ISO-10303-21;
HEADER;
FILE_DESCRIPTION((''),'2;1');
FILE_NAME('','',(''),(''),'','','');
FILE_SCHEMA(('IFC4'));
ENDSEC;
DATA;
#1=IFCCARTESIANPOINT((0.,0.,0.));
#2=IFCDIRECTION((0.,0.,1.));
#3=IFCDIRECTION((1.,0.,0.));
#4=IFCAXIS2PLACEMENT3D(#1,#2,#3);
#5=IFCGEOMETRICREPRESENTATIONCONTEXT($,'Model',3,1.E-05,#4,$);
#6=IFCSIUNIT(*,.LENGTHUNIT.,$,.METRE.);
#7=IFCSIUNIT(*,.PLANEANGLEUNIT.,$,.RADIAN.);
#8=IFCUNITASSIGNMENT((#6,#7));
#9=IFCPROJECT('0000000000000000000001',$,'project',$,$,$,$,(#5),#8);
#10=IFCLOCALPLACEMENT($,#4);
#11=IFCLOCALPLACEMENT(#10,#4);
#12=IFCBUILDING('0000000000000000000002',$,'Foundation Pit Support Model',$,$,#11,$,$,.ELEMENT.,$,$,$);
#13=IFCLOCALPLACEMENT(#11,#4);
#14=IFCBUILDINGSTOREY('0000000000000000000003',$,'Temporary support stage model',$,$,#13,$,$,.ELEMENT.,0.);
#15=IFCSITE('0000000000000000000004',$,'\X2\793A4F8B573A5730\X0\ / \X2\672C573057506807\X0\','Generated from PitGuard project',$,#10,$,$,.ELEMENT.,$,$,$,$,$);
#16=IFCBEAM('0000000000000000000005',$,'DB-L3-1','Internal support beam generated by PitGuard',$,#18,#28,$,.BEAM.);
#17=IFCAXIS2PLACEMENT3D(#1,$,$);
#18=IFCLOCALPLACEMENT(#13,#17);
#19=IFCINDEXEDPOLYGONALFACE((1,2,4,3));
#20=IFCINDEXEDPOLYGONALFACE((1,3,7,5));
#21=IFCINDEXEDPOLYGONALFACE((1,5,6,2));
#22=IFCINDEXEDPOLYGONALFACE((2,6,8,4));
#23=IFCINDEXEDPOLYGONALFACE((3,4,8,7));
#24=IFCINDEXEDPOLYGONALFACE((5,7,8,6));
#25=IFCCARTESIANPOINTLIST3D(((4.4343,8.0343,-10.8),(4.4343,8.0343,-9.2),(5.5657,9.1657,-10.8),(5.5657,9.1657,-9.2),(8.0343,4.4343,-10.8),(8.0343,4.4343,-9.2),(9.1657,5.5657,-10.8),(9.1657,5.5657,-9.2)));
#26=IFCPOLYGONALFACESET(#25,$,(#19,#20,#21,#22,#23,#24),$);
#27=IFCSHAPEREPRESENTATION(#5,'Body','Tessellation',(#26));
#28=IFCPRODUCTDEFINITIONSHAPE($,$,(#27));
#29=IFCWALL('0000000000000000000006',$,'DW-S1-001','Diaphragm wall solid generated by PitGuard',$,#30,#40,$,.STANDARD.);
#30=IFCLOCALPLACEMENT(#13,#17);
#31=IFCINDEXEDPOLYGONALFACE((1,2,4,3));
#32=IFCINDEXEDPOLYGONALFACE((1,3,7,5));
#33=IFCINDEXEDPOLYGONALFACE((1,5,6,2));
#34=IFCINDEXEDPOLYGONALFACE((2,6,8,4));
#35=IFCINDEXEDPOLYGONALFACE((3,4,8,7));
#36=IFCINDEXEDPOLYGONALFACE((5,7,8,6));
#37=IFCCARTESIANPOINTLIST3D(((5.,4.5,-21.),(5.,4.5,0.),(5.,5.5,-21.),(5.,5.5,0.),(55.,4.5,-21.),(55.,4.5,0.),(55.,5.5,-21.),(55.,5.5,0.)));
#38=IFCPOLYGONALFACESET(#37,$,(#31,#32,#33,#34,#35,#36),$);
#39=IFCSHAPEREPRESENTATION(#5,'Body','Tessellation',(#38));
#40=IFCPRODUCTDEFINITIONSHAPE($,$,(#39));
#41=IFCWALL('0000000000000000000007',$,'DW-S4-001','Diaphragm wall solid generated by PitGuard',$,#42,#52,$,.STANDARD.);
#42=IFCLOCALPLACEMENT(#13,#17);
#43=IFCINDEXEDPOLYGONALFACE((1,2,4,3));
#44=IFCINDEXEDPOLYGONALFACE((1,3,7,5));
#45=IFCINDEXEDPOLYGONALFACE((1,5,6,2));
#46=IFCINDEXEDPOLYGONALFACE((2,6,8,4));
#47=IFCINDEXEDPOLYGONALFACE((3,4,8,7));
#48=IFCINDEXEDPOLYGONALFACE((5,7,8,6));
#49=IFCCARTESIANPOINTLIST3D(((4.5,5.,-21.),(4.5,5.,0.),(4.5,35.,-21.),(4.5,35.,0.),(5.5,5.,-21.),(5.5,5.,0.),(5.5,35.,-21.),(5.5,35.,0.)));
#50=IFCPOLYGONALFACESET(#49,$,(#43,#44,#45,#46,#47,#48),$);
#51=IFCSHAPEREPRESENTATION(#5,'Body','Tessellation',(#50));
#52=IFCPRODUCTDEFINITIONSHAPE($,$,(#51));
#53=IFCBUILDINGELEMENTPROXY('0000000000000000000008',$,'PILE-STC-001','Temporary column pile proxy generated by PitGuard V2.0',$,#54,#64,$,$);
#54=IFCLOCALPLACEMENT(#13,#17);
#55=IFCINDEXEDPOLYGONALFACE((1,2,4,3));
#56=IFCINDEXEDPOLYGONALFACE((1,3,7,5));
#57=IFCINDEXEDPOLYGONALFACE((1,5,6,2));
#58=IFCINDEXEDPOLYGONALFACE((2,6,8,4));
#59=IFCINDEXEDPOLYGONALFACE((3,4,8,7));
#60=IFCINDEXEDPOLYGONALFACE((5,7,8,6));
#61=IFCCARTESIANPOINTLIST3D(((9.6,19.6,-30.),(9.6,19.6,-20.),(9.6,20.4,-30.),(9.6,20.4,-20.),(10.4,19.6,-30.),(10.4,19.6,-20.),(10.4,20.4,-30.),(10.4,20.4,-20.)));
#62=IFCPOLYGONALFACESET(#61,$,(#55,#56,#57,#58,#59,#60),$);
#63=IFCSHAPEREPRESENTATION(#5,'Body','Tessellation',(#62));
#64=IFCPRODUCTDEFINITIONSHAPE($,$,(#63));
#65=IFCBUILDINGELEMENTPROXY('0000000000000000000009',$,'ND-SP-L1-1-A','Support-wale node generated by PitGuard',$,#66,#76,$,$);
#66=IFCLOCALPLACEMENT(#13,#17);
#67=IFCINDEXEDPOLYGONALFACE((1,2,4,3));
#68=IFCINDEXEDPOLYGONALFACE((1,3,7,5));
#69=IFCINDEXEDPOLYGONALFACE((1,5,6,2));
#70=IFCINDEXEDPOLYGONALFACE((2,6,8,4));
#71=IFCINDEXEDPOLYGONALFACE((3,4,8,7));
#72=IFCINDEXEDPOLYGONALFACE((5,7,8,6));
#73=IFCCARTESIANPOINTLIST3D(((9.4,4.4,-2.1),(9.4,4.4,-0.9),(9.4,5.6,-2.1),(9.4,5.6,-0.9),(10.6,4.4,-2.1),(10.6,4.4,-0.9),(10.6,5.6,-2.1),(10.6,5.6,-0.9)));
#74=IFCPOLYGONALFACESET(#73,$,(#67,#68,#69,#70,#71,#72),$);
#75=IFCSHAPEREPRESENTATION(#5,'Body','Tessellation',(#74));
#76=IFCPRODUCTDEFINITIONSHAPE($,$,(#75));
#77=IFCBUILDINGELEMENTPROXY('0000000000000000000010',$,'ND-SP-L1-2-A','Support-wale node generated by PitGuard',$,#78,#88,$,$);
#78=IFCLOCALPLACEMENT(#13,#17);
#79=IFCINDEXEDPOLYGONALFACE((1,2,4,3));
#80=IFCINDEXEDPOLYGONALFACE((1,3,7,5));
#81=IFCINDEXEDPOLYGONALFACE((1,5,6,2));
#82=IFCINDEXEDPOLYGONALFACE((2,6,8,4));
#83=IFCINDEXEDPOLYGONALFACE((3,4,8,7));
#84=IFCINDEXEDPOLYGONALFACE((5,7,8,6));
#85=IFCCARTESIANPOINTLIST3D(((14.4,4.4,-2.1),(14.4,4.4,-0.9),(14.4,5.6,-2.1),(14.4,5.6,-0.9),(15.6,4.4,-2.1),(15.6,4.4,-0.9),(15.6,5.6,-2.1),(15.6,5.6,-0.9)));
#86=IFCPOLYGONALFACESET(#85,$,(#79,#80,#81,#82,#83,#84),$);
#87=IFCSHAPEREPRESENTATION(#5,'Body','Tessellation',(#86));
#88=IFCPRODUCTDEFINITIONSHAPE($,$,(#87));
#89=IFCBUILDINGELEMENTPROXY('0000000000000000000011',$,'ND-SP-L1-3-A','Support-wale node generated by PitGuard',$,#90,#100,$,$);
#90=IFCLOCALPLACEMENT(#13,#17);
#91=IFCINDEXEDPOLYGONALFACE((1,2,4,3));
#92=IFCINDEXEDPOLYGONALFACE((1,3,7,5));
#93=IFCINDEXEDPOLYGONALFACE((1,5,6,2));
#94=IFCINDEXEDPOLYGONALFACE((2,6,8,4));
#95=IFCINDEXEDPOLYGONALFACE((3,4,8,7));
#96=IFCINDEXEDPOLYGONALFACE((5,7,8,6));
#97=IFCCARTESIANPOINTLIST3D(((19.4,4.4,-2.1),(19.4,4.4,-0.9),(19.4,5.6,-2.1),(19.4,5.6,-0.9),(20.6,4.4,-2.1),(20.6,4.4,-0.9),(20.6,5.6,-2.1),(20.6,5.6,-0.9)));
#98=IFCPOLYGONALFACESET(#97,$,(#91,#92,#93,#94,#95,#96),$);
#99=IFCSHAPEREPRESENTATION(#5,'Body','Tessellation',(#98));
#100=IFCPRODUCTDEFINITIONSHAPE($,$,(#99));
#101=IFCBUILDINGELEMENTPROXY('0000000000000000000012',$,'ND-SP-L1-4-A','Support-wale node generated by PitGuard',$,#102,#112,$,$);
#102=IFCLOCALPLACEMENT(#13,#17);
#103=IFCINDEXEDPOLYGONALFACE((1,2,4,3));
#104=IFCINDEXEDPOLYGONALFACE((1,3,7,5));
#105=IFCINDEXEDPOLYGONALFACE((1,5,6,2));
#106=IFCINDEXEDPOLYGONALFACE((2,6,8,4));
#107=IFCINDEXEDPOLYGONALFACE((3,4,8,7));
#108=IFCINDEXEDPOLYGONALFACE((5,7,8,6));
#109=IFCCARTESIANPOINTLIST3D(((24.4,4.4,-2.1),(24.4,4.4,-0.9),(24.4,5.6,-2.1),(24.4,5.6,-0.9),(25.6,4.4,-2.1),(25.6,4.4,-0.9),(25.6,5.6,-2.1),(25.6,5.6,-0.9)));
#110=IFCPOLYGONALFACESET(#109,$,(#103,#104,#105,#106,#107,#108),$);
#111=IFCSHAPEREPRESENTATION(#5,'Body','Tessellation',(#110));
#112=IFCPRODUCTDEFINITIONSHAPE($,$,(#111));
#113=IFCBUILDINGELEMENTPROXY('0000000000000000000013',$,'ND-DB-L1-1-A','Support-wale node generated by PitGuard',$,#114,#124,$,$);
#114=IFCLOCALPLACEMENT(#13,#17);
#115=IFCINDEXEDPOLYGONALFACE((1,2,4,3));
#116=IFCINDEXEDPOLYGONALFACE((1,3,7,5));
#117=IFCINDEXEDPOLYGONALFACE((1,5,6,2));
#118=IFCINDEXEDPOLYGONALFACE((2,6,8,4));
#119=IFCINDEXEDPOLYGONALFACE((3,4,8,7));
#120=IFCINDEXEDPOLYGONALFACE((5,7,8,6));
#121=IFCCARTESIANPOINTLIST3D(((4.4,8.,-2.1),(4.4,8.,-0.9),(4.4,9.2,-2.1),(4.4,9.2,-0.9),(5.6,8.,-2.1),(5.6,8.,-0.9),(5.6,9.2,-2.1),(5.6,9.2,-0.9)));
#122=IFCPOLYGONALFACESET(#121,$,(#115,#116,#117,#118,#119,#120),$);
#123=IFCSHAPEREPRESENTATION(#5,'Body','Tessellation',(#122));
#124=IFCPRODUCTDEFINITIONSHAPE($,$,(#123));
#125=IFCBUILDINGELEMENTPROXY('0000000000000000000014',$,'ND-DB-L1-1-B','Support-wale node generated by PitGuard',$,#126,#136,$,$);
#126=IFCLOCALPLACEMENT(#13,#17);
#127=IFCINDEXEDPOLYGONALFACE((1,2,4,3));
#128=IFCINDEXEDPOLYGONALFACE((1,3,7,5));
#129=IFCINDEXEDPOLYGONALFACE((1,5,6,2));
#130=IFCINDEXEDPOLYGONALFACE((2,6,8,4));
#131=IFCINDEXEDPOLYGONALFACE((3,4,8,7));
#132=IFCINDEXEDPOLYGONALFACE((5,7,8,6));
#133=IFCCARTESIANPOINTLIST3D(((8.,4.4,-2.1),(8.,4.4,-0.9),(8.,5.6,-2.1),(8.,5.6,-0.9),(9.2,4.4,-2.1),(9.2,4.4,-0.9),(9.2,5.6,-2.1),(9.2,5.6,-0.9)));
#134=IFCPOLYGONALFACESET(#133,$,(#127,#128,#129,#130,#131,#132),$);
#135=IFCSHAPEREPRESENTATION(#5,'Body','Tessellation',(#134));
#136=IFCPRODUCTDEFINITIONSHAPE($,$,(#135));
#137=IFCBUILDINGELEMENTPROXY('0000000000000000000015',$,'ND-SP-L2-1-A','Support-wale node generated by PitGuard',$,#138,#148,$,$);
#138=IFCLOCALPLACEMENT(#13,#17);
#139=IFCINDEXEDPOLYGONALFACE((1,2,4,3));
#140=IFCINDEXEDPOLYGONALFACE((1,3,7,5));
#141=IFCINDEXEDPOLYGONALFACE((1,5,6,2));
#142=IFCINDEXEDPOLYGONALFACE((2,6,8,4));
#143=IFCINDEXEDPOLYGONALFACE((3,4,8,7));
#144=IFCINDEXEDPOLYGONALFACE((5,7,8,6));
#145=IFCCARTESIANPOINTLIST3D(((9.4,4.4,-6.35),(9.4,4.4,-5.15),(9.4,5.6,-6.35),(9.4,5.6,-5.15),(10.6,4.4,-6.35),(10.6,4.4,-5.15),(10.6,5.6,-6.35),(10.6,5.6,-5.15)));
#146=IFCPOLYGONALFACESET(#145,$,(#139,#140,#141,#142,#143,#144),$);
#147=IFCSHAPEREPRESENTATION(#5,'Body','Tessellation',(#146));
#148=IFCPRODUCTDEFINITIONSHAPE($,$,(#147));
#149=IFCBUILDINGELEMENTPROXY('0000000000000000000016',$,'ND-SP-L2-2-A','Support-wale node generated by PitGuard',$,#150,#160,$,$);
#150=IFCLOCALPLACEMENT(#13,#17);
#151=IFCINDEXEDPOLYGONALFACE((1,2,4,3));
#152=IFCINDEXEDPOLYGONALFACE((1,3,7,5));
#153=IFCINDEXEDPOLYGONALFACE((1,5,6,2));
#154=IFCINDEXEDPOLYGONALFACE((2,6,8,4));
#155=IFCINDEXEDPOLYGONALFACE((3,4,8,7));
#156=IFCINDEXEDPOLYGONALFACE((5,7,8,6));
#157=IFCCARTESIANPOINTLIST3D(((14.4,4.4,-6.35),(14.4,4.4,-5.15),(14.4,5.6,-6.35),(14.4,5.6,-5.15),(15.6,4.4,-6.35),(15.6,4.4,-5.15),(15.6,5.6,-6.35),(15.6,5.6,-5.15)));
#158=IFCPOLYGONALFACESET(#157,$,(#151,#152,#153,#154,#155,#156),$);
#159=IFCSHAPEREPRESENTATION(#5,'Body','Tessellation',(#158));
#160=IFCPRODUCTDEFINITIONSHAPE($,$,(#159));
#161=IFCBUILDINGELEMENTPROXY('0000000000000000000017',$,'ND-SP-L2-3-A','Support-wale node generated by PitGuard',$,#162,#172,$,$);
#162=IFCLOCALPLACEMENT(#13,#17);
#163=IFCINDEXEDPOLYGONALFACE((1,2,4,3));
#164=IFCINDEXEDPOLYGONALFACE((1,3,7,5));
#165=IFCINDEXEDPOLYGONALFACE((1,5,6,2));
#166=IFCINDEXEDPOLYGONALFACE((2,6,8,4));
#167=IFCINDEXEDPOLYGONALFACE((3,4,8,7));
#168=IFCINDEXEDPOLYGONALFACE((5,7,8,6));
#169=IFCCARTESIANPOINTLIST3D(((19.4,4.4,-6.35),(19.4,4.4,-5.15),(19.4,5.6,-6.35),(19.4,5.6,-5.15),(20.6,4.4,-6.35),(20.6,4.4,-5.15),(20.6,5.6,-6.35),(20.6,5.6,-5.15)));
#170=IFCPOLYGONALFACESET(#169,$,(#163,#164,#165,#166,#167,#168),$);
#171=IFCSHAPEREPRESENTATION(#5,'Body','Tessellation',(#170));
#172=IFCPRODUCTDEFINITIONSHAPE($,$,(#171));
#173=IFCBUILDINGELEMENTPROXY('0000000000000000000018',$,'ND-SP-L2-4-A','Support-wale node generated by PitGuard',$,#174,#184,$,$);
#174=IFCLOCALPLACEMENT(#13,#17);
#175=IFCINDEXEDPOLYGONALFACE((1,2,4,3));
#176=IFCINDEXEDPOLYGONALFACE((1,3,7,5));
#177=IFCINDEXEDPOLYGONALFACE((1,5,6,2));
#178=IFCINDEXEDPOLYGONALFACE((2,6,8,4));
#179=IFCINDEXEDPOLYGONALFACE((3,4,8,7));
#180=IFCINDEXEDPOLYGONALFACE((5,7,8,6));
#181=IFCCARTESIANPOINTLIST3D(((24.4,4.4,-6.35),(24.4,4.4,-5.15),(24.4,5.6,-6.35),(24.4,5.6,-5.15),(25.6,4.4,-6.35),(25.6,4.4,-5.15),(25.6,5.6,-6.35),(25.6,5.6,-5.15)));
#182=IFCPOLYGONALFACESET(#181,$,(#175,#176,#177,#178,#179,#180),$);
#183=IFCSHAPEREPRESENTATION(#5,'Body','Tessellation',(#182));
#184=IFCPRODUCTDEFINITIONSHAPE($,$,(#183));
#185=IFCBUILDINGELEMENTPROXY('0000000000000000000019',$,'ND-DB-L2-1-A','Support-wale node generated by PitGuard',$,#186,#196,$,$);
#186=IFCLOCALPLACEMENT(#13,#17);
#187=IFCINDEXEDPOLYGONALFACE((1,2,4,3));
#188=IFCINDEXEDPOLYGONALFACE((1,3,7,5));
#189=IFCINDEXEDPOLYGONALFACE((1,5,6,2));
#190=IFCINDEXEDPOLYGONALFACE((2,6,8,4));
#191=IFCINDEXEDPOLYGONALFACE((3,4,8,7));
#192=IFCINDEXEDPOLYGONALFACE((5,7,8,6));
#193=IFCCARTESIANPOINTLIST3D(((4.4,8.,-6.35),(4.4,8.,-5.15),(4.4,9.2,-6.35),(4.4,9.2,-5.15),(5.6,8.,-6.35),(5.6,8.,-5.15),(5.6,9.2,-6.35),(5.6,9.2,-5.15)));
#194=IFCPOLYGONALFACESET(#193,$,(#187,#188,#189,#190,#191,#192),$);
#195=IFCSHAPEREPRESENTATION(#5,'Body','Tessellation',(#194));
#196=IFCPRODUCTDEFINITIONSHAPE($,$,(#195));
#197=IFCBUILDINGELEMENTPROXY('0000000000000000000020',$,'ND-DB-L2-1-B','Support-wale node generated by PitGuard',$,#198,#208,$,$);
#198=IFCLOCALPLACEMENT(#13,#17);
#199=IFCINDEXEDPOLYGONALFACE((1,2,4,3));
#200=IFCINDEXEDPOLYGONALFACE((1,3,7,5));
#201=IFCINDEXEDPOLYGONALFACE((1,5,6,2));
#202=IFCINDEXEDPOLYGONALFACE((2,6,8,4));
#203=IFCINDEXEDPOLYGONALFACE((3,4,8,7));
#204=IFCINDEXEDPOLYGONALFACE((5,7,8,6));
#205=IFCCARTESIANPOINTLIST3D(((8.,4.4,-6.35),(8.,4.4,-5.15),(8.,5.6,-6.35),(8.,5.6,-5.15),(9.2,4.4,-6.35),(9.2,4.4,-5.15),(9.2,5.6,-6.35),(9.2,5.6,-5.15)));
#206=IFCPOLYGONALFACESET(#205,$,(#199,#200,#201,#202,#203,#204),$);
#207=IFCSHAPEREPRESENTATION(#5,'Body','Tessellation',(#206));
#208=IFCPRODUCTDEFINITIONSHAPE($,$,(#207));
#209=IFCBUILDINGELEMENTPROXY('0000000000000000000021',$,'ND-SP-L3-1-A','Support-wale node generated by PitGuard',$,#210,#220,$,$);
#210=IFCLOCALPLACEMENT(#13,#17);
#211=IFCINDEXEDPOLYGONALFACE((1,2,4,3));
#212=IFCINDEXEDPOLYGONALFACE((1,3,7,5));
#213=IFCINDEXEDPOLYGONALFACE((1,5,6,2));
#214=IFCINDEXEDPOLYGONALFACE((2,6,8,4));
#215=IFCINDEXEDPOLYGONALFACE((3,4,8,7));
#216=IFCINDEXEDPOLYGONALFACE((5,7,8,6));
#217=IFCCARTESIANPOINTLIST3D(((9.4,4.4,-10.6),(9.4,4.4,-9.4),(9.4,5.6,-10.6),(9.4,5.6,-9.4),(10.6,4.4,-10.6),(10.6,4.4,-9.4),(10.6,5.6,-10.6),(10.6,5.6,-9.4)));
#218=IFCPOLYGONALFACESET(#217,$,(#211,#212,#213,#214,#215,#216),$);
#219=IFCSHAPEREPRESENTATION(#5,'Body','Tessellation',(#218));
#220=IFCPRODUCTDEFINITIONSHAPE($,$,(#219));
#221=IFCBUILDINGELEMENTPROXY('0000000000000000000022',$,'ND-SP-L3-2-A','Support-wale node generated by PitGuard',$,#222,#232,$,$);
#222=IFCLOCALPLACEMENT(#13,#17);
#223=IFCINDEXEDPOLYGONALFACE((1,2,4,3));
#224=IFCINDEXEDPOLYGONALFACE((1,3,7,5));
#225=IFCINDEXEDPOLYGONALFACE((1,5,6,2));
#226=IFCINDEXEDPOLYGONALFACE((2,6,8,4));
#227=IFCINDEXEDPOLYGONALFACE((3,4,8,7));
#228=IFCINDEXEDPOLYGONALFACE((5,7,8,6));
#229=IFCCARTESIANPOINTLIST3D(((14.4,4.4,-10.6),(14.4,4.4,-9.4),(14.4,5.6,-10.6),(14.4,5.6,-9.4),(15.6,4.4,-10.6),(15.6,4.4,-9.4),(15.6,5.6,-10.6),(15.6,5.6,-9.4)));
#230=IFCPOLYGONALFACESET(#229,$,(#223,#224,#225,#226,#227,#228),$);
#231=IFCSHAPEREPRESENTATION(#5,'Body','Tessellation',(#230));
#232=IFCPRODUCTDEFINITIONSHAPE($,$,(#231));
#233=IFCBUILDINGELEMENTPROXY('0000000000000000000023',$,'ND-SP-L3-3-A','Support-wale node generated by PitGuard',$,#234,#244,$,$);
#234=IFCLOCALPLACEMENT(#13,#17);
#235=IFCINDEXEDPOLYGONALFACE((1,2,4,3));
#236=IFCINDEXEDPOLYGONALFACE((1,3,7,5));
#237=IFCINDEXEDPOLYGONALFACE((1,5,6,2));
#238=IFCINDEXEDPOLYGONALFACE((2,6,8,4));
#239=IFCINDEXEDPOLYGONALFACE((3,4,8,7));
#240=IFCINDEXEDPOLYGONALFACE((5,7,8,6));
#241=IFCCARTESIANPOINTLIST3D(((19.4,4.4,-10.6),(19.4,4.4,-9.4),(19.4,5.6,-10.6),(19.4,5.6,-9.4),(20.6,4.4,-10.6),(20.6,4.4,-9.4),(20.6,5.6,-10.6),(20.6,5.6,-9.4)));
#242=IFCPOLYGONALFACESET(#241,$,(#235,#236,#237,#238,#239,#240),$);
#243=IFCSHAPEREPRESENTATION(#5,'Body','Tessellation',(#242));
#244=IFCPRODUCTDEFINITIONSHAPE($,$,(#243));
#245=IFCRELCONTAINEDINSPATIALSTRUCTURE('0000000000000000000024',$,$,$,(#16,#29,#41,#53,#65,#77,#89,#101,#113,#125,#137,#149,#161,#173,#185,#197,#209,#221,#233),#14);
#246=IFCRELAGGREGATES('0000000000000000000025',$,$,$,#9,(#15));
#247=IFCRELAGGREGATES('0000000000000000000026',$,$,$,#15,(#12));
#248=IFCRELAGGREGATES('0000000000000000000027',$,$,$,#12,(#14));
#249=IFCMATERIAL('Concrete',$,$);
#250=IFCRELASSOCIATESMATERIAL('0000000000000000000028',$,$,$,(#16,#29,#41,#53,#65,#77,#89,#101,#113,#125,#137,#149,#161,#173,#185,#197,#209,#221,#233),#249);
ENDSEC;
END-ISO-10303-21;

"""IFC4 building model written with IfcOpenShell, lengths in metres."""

from ifc_helpers import new_model, si_unit, frame, origin_with_axes, origin_2d, place, context, project, spatial, rectangle, extrude, material, element, save


model = new_model("IFC4")

# Units and contexts
model_context = context("Model", 3, precision=1e-05, world=origin_with_axes())
ifc_project = project(units=[si_unit("LENGTHUNIT", "METRE"), si_unit("PLANEANGLEUNIT", "RADIAN")], contexts=[model_context])

# Site, building, storey
site_placement = place(None, origin_with_axes())
site = spatial("IfcSite", under=ifc_project, at=site_placement, Name="示例场地 / 本地坐标", Description="Generated from PitGuard project", CompositionType="ELEMENT")
building_placement = place(site_placement, origin_with_axes())
building = spatial("IfcBuilding", under=site, at=building_placement, Name="Foundation Pit Support Model", CompositionType="ELEMENT")
storey_placement = place(building_placement, origin_with_axes())
storey = spatial("IfcBuildingStorey", under=building, at=storey_placement, Name="Temporary support stage model", CompositionType="ELEMENT", Elevation=0.0)

# Beam
ifc_material_1 = material(Name="Concrete")
beam_1_placement = place(storey_placement, frame((6.8, 6.8, -10.8), z_axis=(0.0, 0.0, 1.0), x_axis=(0.707107, -0.707107, 0.0)))
element("IfcBeam", 1, at=beam_1_placement, inside=storey, material=ifc_material_1, Name="DB-L3-1", Description="Internal support beam generated by PitGuard", PredefinedType="BEAM", context=model_context, shape_type="SweptSolid", body=[
    extrude(rectangle(XDim=5.0912, YDim=1.6, at=origin_2d()), origin_with_axes(), (0.0, 0.0, 1.0), 1.6),
])

# Walls
wall_1_placement = place(storey_placement, frame((30.0, 5.0, -21.0), z_axis=(0.0, 0.0, 1.0), x_axis=(1.0, 0.0, 0.0)))
element("IfcWall", 2, at=wall_1_placement, inside=storey, material=ifc_material_1, Name="DW-S1-001", Description="Diaphragm wall solid generated by PitGuard", PredefinedType="STANDARD", context=model_context, shape_type="SweptSolid", body=[
    extrude(rectangle(XDim=50.0, YDim=1.0, at=origin_2d()), origin_with_axes(), (0.0, 0.0, 1.0), 21.0),
])
wall_2_placement = place(storey_placement, frame((5.0, 20.0, -21.0), z_axis=(0.0, 0.0, 1.0), x_axis=(0.0, -1.0, 0.0)))
element("IfcWall", 3, at=wall_2_placement, inside=storey, material=ifc_material_1, Name="DW-S4-001", Description="Diaphragm wall solid generated by PitGuard", PredefinedType="STANDARD", context=model_context, shape_type="SweptSolid", body=[
    extrude(rectangle(XDim=30.0, YDim=1.0, at=origin_2d()), origin_with_axes(), (0.0, 0.0, 1.0), 21.0),
])

# Building element proxies
proxy_placement = place(storey_placement, frame((10.0, 20.0, -30.0), z_axis=(0.0, 0.0, 1.0), x_axis=(1.0, 0.0, 0.0)))
element("IfcBuildingElementProxy", 4, at=proxy_placement, inside=storey, material=ifc_material_1, Name="PILE-STC-001", Description="Temporary column pile proxy generated by PitGuard V2.0", context=model_context, shape_type="SweptSolid", body=[
    extrude(rectangle(XDim=0.8, YDim=0.8, at=origin_2d()), origin_with_axes(), (0.0, 0.0, 1.0), 10.0),
])
for number, where, z_axis, x_axis, name in (
    (5, (10.0, 5.0, -2.1), (0.0, 0.0, 1.0), (1.0, 0.0, 0.0), "ND-SP-L1-1-A"),
    (6, (15.0, 5.0, -2.1), (0.0, 0.0, 1.0), (1.0, 0.0, 0.0), "ND-SP-L1-2-A"),
    (7, (20.0, 5.0, -2.1), (0.0, 0.0, 1.0), (1.0, 0.0, 0.0), "ND-SP-L1-3-A"),
    (8, (25.0, 5.0, -2.1), (0.0, 0.0, 1.0), (1.0, 0.0, 0.0), "ND-SP-L1-4-A"),
    (9, (5.0, 8.6, -2.1), (0.0, 0.0, 1.0), (1.0, 0.0, 0.0), "ND-DB-L1-1-A"),
    (10, (8.6, 5.0, -2.1), (0.0, 0.0, 1.0), (1.0, 0.0, 0.0), "ND-DB-L1-1-B"),
    (11, (10.0, 5.0, -6.35), (0.0, 0.0, 1.0), (1.0, 0.0, 0.0), "ND-SP-L2-1-A"),
    (12, (15.0, 5.0, -6.35), (0.0, 0.0, 1.0), (1.0, 0.0, 0.0), "ND-SP-L2-2-A"),
    (13, (20.0, 5.0, -6.35), (0.0, 0.0, 1.0), (1.0, 0.0, 0.0), "ND-SP-L2-3-A"),
    (14, (25.0, 5.0, -6.35), (0.0, 0.0, 1.0), (1.0, 0.0, 0.0), "ND-SP-L2-4-A"),
    (15, (5.0, 8.6, -6.35), (0.0, 0.0, 1.0), (1.0, 0.0, 0.0), "ND-DB-L2-1-A"),
    (16, (8.6, 5.0, -6.35), (0.0, 0.0, 1.0), (1.0, 0.0, 0.0), "ND-DB-L2-1-B"),
    (17, (10.0, 5.0, -10.6), (0.0, 0.0, 1.0), (1.0, 0.0, 0.0), "ND-SP-L3-1-A"),
    (18, (15.0, 5.0, -10.6), (0.0, 0.0, 1.0), (1.0, 0.0, 0.0), "ND-SP-L3-2-A"),
    (19, (20.0, 5.0, -10.6), (0.0, 0.0, 1.0), (1.0, 0.0, 0.0), "ND-SP-L3-3-A"),
):
    element("IfcBuildingElementProxy", number, at=place(storey_placement, frame(where, z_axis=z_axis, x_axis=x_axis)), inside=storey, material=ifc_material_1, Name=name, Description="Support-wale node generated by PitGuard", context=model_context, shape_type="SweptSolid", body=[
        extrude(rectangle(XDim=1.2, YDim=1.2, at=origin_2d()), origin_with_axes(), (0.0, 0.0, 1.0), 1.2),
    ])

save(model, "model.ifc")
